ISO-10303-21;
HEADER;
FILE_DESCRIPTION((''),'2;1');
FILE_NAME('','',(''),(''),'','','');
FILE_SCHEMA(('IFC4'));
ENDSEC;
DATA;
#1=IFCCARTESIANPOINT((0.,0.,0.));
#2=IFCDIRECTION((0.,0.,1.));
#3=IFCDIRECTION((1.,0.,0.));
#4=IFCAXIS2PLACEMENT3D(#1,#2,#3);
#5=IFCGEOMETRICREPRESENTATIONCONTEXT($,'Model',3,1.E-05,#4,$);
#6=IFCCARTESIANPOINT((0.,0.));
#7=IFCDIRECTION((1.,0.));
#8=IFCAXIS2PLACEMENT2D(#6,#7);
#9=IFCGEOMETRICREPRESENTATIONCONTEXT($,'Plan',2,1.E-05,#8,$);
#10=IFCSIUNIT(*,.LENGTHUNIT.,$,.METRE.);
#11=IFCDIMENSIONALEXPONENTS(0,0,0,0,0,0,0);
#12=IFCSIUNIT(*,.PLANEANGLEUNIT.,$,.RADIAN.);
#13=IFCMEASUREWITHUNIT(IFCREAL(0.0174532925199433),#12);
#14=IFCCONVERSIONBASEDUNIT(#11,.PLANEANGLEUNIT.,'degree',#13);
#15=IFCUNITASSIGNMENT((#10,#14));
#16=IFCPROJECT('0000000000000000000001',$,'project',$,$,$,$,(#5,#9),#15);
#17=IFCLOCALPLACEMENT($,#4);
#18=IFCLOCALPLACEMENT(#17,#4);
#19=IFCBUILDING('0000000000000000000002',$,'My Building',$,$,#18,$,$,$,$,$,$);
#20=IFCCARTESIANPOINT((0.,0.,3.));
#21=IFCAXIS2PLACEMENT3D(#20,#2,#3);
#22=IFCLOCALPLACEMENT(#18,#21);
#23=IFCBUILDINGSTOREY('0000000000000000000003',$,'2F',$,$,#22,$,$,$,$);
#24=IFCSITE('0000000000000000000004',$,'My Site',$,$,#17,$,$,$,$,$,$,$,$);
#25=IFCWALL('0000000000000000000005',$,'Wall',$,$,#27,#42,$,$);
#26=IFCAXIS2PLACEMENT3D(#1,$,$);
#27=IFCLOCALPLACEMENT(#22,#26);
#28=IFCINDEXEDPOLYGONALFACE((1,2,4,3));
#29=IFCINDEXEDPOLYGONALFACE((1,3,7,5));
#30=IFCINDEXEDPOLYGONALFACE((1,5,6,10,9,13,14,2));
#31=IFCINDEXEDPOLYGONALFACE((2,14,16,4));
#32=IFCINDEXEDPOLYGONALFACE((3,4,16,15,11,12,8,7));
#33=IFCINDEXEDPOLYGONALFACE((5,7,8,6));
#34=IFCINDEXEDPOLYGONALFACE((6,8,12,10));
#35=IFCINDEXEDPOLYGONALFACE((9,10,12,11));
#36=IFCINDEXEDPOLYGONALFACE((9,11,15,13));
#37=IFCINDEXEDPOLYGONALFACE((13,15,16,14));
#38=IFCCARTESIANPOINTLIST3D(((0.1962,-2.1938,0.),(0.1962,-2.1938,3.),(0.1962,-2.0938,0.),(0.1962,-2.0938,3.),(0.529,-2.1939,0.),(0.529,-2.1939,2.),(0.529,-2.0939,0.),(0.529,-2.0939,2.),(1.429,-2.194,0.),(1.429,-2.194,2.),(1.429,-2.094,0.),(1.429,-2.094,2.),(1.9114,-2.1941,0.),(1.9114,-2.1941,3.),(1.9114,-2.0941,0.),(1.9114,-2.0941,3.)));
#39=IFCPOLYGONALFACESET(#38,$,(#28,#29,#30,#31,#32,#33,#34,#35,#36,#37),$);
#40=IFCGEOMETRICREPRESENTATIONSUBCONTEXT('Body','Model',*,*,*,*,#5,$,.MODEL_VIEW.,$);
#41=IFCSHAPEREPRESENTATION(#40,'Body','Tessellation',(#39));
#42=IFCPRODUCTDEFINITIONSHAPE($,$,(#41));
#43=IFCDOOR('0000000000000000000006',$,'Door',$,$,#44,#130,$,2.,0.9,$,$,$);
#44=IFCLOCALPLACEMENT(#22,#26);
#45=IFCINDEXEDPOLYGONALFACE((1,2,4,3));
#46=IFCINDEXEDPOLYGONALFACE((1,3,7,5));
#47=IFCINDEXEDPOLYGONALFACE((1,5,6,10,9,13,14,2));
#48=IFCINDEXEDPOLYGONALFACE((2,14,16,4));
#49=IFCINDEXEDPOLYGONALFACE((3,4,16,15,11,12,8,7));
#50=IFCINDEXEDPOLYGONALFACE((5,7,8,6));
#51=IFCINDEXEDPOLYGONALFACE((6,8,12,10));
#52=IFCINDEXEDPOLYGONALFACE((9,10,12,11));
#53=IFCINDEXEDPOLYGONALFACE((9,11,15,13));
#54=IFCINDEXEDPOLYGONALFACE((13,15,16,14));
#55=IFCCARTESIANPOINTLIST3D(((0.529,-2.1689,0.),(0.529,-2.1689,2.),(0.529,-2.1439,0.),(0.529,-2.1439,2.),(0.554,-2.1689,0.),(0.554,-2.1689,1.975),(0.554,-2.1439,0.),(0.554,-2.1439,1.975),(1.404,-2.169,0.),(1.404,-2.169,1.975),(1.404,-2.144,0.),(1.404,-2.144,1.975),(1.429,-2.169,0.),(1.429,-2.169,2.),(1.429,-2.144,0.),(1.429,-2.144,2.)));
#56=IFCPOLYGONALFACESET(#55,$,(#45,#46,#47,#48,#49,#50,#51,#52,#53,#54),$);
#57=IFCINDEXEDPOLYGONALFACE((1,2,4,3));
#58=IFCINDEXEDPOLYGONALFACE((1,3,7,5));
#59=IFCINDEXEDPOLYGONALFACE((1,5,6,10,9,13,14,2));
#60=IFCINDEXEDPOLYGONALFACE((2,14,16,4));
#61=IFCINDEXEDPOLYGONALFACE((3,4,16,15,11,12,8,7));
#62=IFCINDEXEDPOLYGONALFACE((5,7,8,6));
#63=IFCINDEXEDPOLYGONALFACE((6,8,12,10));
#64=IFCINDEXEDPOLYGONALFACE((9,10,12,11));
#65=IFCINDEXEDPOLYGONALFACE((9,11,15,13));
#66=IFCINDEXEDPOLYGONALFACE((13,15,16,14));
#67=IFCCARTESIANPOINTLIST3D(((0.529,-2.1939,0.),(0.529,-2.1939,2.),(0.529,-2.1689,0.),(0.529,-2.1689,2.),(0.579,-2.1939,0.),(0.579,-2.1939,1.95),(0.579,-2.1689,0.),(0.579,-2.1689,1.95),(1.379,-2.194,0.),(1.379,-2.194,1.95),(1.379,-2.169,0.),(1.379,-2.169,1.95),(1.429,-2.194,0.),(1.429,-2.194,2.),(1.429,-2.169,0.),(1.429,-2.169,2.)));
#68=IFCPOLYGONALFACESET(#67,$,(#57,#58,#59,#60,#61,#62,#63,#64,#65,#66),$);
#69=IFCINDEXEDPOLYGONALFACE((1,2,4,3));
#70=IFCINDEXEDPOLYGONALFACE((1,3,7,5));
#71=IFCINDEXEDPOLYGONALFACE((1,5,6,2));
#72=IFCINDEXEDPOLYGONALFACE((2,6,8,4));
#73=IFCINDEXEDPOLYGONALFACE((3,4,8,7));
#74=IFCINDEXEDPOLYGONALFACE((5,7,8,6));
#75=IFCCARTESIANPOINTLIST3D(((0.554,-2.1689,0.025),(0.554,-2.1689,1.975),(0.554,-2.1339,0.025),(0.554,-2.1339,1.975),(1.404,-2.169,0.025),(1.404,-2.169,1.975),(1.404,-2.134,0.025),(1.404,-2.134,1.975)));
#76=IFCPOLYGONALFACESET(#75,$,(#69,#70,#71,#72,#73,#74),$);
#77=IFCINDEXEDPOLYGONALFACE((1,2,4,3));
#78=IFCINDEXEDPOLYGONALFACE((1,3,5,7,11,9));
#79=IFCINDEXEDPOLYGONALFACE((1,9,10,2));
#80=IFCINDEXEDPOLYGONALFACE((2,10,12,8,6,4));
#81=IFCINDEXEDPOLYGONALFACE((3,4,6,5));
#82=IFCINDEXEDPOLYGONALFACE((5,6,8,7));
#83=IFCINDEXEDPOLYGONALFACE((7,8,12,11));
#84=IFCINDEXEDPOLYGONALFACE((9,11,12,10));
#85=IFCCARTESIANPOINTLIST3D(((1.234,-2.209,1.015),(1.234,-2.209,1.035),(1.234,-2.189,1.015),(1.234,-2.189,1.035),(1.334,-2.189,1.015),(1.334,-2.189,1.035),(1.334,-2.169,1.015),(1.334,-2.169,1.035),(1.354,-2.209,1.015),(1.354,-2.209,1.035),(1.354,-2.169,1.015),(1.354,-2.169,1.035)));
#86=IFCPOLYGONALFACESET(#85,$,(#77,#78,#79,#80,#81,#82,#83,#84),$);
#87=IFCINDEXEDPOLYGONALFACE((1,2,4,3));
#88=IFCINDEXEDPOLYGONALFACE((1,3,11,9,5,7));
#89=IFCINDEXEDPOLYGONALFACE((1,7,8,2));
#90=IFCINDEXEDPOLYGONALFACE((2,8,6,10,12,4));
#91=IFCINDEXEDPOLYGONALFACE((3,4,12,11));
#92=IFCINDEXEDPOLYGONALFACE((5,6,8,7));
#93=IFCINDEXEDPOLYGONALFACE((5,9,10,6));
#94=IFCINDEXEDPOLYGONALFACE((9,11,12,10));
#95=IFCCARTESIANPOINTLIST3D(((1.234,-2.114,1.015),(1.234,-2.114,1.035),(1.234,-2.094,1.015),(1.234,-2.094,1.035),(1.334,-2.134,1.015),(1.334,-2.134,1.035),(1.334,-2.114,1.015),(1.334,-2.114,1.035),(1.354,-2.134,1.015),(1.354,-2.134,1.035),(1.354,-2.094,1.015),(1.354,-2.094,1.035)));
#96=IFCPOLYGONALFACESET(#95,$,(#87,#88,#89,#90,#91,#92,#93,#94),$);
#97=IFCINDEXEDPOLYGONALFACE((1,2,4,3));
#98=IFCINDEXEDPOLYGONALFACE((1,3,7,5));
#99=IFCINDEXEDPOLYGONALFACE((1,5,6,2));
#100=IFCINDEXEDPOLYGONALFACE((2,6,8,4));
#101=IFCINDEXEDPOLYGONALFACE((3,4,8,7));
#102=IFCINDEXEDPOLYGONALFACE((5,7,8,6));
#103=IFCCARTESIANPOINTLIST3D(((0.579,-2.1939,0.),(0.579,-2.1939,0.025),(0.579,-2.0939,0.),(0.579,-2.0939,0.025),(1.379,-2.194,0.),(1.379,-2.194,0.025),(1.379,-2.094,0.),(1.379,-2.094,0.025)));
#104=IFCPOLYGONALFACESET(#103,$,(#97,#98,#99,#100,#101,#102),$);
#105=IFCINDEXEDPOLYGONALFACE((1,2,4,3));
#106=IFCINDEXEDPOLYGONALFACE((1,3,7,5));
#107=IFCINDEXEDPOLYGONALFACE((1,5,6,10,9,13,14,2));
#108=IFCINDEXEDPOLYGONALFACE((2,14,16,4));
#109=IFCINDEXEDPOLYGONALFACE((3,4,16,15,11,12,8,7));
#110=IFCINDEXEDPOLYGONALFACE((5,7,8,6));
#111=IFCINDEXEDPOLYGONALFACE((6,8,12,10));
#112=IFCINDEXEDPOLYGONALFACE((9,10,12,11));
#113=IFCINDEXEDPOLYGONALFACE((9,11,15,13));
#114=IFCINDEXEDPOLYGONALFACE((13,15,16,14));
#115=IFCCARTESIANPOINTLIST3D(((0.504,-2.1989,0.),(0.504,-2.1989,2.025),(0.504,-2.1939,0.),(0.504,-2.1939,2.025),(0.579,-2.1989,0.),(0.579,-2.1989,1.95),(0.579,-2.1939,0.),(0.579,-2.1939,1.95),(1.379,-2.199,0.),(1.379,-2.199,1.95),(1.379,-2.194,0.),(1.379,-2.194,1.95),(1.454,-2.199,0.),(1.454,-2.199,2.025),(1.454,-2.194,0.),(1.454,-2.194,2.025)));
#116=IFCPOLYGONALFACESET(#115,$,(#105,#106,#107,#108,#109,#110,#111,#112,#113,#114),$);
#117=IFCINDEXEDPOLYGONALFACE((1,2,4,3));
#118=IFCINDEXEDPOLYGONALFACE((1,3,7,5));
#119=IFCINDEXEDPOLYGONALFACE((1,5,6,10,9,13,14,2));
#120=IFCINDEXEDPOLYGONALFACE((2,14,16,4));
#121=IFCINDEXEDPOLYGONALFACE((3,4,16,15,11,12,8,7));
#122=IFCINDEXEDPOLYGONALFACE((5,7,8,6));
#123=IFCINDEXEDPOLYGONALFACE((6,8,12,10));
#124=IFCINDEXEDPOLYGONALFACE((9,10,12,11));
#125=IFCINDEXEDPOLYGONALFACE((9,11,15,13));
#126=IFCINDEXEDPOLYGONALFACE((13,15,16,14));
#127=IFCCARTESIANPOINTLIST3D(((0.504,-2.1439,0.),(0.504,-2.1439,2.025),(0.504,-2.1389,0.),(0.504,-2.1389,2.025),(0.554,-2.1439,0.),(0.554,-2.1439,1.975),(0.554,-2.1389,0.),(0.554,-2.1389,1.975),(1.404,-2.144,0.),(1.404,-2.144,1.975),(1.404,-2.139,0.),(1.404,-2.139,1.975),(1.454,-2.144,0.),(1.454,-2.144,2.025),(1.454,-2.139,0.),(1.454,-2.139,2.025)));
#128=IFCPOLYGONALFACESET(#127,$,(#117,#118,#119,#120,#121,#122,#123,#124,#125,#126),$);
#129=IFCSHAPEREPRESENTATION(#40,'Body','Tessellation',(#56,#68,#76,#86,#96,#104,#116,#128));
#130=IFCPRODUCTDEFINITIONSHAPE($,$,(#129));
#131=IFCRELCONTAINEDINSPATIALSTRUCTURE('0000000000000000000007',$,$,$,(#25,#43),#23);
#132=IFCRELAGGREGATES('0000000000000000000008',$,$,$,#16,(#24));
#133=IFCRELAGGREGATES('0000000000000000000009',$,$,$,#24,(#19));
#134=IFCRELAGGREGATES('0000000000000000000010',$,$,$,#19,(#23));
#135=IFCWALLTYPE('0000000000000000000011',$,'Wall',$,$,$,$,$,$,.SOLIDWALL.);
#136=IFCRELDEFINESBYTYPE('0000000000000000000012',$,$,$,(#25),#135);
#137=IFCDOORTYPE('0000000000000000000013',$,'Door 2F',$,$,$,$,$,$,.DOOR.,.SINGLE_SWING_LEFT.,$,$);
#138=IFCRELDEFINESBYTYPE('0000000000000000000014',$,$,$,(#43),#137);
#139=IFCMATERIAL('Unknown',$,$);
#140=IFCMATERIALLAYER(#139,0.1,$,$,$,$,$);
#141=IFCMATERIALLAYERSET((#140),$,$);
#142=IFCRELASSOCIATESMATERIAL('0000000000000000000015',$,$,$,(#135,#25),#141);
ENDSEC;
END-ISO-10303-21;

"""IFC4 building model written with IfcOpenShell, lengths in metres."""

from ifc_helpers import new_model, entity, si_unit, converted_unit, frame, origin_with_axes, origin_2d_with_axis, place, context, subcontext, project, spatial, line, indexed_curve, outline, extrude, shape, source, transform, mapped, material, layer, layer_set, layer_usage, type_object, type_shapes, element, fill, save


model = new_model("IFC4")

# Units and contexts
model_context = context("Model", 3, precision=1e-05, world=origin_with_axes())
plan_context = context("Plan", 2, precision=1e-05, world=origin_2d_with_axis())
body_context_1 = subcontext(model_context, "Body", "Model", "MODEL_VIEW")
body_context_2 = subcontext(plan_context, "Body", "Plan", "PLAN_VIEW")
ifc_project = project(units=[si_unit("LENGTHUNIT", "METRE"), converted_unit("PLANEANGLEUNIT", "degree", entity("IfcReal", 0.0174532925199433), si_unit("PLANEANGLEUNIT", "RADIAN"), dimensions=[0, 0, 0, 0, 0, 0, 0])], contexts=[model_context, plan_context])

# Site, building, storey
site_placement = place(None, origin_with_axes())
site = spatial("IfcSite", under=ifc_project, at=site_placement, Name="My Site")
building_placement = place(site_placement, origin_with_axes())
building = spatial("IfcBuilding", under=site, at=building_placement, Name="My Building")
storey_placement = place(building_placement, frame((0.0, 0.0, 3.0), z_axis=(0.0, 0.0, 1.0), x_axis=(1.0, 0.0, 0.0)))
storey = spatial("IfcBuildingStorey", under=building, at=storey_placement, Name="2F")

# Shared definitions
ifc_material = material(Name="Unknown")

# Shared definitions
ifc_layer_1 = layer(ifc_material, 0.1)
ifc_layer_set_1 = layer_set([ifc_layer_1])
wall_type = type_object("IfcWallType", Name="Wall", PredefinedType="SOLIDWALL", material=ifc_layer_set_1)

# Wall, opening, door
ifc_layer_usage_1 = layer_usage(ifc_layer_set_1, "AXIS2", "POSITIVE", 0.0)
wall_1_placement = place(storey_placement, frame((0.1962, -2.1938, 0.0), z_axis=(0.0, 0.0, 1.0), x_axis=(1.0, -0.00013, 0.0)))
wall_1 = element("IfcWall", 1, at=wall_1_placement, inside=storey, type_object=wall_type, material=ifc_layer_usage_1, Name="Wall", context=body_context_1, shape_type="SweptSolid", body=[
    extrude(outline(indexed_curve([(0.0, 0.0), (0.0, 0.1), (1.7152, 0.1), (1.7152, 0.0)], segments=[line(1, 2, 3, 4, 1)])), origin_with_axes(), (0.0, 0.0, 1.0), 3.0),
])
shared_shape_1 = source(origin_with_axes(), body_context_1, "Body", "SweptSolid", [
    extrude(outline(indexed_curve([(0.0, 0.0), (0.9, 0.0), (0.9, 2.0), (0.0, 2.0)], segments=[line(1, 2, 3, 4, 1)])), frame((0.0, -0.6, 0.0), z_axis=(0.0, -1.0, 0.0), x_axis=(1.0, 0.0, 0.0)), (0.0, 0.0, -1.0), 1.2),
])
opening_1_placement = place(wall_1_placement, frame((0.3327, 0.0, 0.0), z_axis=(0.0, 0.0, 1.0), x_axis=(1.0, 0.0, 0.0)))
opening_1 = element("IfcOpeningElement", 2, at=opening_1_placement, cuts=wall_1, PredefinedType="OPENING", context=body_context_1, shape_type="MappedRepresentation", body=[
    mapped(shared_shape_1, transform((0.0, 0.0, 0.0), x_axis=(1.0, 0.0, 0.0), y_axis=(0.0, 1.0, 0.0), z_axis=(0.0, 0.0, 1.0), scale=1.0)),
])
door_type_1 = type_object("IfcDoorType", Name="Door 2F", OperationType="SINGLE_SWING_LEFT", PredefinedType="DOOR")
shared_shape_2 = source(origin_with_axes(), body_context_1, "Body", "SweptSolid", [
    extrude(outline(indexed_curve([(0.0, 0.0), (0.0, 2.0), (0.9, 2.0), (0.9, 0.0), (0.875, 0.0), (0.875, 1.975), (0.025, 1.975), (0.025, 0.0)], segments=[line(1, 2, 3, 4, 5, 6, 7, 8, 1)])), frame((0.0, 0.025, 0.0), z_axis=(0.0, -1.0, 0.0), x_axis=(1.0, 0.0, 0.0)), (0.0, 0.0, -1.0), 0.025),
    extrude(outline(indexed_curve([(0.0, 0.0), (0.0, 2.0), (0.9, 2.0), (0.9, 0.0), (0.85, 0.0), (0.85, 1.95), (0.05, 1.95), (0.05, 0.0)], segments=[line(1, 2, 3, 4, 5, 6, 7, 8, 1)])), frame((0.0, 0.0, 0.0), z_axis=(0.0, -1.0, 0.0), x_axis=(1.0, 0.0, 0.0)), (0.0, 0.0, -1.0), 0.025),
    extrude(outline(indexed_curve([(0.0, 0.0), (0.85, 0.0), (0.85, 0.035), (0.0, 0.035)], segments=[line(1, 2, 3, 4, 1)])), frame((0.025, 0.025, 0.025), z_axis=(0.0, 0.0, 1.0), x_axis=(1.0, 0.0, 0.0)), (0.0, 0.0, 1.0), 1.95),
    extrude(outline(indexed_curve([(0.0, 0.0), (0.0, -0.04), (-0.12, -0.04), (-0.12, -0.02), (-0.02, -0.02), (-0.02, 0.0)], segments=[line(1, 2, 3, 4, 5, 6, 1)])), frame((0.825, 0.025, 1.015), z_axis=(0.0, 0.0, 1.0), x_axis=(1.0, 0.0, 0.0)), (0.0, 0.0, 1.0), 0.02),
    extrude(outline(indexed_curve([(0.0, 0.0), (0.0, 0.04), (-0.12, 0.04), (-0.12, 0.02), (-0.02, 0.02), (-0.02, 0.0)], segments=[line(1, 2, 3, 4, 5, 6, 1)])), frame((0.825, 0.06, 1.015), z_axis=(0.0, 0.0, 1.0), x_axis=(1.0, 0.0, 0.0)), (0.0, 0.0, 1.0), 0.02),
    extrude(outline(indexed_curve([(0.0, 0.0), (0.8, 0.0), (0.8, 0.1), (0.0, 0.1)], segments=[line(1, 2, 3, 4, 1)])), frame((0.05, 0.0, 0.0), z_axis=(0.0, 0.0, 1.0), x_axis=(1.0, 0.0, 0.0)), (0.0, 0.0, 1.0), 0.025),
    extrude(outline(indexed_curve([(0.0, 0.0), (0.0, 2.025), (0.95, 2.025), (0.95, 0.0), (0.875, 0.0), (0.875, 1.95), (0.075, 1.95), (0.075, 0.0)], segments=[line(1, 2, 3, 4, 5, 6, 7, 8, 1)])), frame((-0.025, -0.005, 0.0), z_axis=(0.0, -1.0, 0.0), x_axis=(1.0, 0.0, 0.0)), (0.0, 0.0, -1.0), 0.005),
    extrude(outline(indexed_curve([(0.0, 0.0), (0.0, 2.025), (0.95, 2.025), (0.95, 0.0), (0.9, 0.0), (0.9, 1.975), (0.05, 1.975), (0.05, 0.0)], segments=[line(1, 2, 3, 4, 5, 6, 7, 8, 1)])), frame((-0.025, 0.05, 0.0), z_axis=(0.0, -1.0, 0.0), x_axis=(1.0, 0.0, 0.0)), (0.0, 0.0, -1.0), 0.005),
])
shared_shape_3 = source(origin_with_axes(), body_context_2, "Body", "Curve2D", [
    entity("IfcIndexedPolyCurve", entity("IfcCartesianPointList2D", [[0.0, 0.0], [0.0, 0.05], [0.025, 0.05], [0.025, 0.025], [0.05, 0.025], [0.05, 0.0]]), [entity("IfcLineIndex", [1, 2, 3, 4, 5, 6, 1])]),
    entity("IfcIndexedPolyCurve", entity("IfcCartesianPointList2D", [[0.9, 0.0], [0.9, 0.05], [0.875, 0.05], [0.875, 0.025], [0.85, 0.025], [0.85, 0.0]]), [entity("IfcLineIndex", [1, 2, 3, 4, 5, 6, 1])]),
    entity("IfcTrimmedCurve", entity("IfcEllipse", entity("IfcAxis2Placement2D", entity("IfcCartesianPoint", [0.06, 0.05]), entity("IfcDirection", [1.0, 0.0])), 0.815, 0.85), [entity("IfcCartesianPoint", [0.875, 0.05])], [entity("IfcCartesianPoint", [0.06, 0.9])], True, "CARTESIAN"),
    entity("IfcIndexedPolyCurve", entity("IfcCartesianPointList2D", [[0.025, 0.05], [0.06, 0.05], [0.06, 0.9], [0.025, 0.9]]), [entity("IfcLineIndex", [1, 2, 3, 4, 1])]),
])
type_shapes(door_type_1, [shared_shape_2, shared_shape_3])
door_1_placement = place(opening_1_placement, frame((0.0, 0.0, 0.0), z_axis=(0.0, 0.0, 1.0), x_axis=(1.0, 0.0, 0.0)))
door_1 = element("IfcDoor", 3, at=door_1_placement, inside=storey, type_object=door_type_1, Name="Door", OverallHeight=2.0, OverallWidth=0.9, shapes=[
    shape(body_context_1, "Body", "MappedRepresentation", [mapped(shared_shape_2, transform((0.0, 0.0, 0.0), x_axis=(1.0, 0.0, 0.0), y_axis=(0.0, 1.0, 0.0), z_axis=(0.0, 0.0, 1.0), scale=1.0))]),
    shape(body_context_2, "Body", "MappedRepresentation", [mapped(shared_shape_3, transform((0.0, 0.0, 0.0), x_axis=(1.0, 0.0, 0.0), y_axis=(0.0, 1.0, 0.0), z_axis=(0.0, 0.0, 1.0), scale=1.0))]),
])
fill(opening_1, door_1)

save(model, "model.ifc")
